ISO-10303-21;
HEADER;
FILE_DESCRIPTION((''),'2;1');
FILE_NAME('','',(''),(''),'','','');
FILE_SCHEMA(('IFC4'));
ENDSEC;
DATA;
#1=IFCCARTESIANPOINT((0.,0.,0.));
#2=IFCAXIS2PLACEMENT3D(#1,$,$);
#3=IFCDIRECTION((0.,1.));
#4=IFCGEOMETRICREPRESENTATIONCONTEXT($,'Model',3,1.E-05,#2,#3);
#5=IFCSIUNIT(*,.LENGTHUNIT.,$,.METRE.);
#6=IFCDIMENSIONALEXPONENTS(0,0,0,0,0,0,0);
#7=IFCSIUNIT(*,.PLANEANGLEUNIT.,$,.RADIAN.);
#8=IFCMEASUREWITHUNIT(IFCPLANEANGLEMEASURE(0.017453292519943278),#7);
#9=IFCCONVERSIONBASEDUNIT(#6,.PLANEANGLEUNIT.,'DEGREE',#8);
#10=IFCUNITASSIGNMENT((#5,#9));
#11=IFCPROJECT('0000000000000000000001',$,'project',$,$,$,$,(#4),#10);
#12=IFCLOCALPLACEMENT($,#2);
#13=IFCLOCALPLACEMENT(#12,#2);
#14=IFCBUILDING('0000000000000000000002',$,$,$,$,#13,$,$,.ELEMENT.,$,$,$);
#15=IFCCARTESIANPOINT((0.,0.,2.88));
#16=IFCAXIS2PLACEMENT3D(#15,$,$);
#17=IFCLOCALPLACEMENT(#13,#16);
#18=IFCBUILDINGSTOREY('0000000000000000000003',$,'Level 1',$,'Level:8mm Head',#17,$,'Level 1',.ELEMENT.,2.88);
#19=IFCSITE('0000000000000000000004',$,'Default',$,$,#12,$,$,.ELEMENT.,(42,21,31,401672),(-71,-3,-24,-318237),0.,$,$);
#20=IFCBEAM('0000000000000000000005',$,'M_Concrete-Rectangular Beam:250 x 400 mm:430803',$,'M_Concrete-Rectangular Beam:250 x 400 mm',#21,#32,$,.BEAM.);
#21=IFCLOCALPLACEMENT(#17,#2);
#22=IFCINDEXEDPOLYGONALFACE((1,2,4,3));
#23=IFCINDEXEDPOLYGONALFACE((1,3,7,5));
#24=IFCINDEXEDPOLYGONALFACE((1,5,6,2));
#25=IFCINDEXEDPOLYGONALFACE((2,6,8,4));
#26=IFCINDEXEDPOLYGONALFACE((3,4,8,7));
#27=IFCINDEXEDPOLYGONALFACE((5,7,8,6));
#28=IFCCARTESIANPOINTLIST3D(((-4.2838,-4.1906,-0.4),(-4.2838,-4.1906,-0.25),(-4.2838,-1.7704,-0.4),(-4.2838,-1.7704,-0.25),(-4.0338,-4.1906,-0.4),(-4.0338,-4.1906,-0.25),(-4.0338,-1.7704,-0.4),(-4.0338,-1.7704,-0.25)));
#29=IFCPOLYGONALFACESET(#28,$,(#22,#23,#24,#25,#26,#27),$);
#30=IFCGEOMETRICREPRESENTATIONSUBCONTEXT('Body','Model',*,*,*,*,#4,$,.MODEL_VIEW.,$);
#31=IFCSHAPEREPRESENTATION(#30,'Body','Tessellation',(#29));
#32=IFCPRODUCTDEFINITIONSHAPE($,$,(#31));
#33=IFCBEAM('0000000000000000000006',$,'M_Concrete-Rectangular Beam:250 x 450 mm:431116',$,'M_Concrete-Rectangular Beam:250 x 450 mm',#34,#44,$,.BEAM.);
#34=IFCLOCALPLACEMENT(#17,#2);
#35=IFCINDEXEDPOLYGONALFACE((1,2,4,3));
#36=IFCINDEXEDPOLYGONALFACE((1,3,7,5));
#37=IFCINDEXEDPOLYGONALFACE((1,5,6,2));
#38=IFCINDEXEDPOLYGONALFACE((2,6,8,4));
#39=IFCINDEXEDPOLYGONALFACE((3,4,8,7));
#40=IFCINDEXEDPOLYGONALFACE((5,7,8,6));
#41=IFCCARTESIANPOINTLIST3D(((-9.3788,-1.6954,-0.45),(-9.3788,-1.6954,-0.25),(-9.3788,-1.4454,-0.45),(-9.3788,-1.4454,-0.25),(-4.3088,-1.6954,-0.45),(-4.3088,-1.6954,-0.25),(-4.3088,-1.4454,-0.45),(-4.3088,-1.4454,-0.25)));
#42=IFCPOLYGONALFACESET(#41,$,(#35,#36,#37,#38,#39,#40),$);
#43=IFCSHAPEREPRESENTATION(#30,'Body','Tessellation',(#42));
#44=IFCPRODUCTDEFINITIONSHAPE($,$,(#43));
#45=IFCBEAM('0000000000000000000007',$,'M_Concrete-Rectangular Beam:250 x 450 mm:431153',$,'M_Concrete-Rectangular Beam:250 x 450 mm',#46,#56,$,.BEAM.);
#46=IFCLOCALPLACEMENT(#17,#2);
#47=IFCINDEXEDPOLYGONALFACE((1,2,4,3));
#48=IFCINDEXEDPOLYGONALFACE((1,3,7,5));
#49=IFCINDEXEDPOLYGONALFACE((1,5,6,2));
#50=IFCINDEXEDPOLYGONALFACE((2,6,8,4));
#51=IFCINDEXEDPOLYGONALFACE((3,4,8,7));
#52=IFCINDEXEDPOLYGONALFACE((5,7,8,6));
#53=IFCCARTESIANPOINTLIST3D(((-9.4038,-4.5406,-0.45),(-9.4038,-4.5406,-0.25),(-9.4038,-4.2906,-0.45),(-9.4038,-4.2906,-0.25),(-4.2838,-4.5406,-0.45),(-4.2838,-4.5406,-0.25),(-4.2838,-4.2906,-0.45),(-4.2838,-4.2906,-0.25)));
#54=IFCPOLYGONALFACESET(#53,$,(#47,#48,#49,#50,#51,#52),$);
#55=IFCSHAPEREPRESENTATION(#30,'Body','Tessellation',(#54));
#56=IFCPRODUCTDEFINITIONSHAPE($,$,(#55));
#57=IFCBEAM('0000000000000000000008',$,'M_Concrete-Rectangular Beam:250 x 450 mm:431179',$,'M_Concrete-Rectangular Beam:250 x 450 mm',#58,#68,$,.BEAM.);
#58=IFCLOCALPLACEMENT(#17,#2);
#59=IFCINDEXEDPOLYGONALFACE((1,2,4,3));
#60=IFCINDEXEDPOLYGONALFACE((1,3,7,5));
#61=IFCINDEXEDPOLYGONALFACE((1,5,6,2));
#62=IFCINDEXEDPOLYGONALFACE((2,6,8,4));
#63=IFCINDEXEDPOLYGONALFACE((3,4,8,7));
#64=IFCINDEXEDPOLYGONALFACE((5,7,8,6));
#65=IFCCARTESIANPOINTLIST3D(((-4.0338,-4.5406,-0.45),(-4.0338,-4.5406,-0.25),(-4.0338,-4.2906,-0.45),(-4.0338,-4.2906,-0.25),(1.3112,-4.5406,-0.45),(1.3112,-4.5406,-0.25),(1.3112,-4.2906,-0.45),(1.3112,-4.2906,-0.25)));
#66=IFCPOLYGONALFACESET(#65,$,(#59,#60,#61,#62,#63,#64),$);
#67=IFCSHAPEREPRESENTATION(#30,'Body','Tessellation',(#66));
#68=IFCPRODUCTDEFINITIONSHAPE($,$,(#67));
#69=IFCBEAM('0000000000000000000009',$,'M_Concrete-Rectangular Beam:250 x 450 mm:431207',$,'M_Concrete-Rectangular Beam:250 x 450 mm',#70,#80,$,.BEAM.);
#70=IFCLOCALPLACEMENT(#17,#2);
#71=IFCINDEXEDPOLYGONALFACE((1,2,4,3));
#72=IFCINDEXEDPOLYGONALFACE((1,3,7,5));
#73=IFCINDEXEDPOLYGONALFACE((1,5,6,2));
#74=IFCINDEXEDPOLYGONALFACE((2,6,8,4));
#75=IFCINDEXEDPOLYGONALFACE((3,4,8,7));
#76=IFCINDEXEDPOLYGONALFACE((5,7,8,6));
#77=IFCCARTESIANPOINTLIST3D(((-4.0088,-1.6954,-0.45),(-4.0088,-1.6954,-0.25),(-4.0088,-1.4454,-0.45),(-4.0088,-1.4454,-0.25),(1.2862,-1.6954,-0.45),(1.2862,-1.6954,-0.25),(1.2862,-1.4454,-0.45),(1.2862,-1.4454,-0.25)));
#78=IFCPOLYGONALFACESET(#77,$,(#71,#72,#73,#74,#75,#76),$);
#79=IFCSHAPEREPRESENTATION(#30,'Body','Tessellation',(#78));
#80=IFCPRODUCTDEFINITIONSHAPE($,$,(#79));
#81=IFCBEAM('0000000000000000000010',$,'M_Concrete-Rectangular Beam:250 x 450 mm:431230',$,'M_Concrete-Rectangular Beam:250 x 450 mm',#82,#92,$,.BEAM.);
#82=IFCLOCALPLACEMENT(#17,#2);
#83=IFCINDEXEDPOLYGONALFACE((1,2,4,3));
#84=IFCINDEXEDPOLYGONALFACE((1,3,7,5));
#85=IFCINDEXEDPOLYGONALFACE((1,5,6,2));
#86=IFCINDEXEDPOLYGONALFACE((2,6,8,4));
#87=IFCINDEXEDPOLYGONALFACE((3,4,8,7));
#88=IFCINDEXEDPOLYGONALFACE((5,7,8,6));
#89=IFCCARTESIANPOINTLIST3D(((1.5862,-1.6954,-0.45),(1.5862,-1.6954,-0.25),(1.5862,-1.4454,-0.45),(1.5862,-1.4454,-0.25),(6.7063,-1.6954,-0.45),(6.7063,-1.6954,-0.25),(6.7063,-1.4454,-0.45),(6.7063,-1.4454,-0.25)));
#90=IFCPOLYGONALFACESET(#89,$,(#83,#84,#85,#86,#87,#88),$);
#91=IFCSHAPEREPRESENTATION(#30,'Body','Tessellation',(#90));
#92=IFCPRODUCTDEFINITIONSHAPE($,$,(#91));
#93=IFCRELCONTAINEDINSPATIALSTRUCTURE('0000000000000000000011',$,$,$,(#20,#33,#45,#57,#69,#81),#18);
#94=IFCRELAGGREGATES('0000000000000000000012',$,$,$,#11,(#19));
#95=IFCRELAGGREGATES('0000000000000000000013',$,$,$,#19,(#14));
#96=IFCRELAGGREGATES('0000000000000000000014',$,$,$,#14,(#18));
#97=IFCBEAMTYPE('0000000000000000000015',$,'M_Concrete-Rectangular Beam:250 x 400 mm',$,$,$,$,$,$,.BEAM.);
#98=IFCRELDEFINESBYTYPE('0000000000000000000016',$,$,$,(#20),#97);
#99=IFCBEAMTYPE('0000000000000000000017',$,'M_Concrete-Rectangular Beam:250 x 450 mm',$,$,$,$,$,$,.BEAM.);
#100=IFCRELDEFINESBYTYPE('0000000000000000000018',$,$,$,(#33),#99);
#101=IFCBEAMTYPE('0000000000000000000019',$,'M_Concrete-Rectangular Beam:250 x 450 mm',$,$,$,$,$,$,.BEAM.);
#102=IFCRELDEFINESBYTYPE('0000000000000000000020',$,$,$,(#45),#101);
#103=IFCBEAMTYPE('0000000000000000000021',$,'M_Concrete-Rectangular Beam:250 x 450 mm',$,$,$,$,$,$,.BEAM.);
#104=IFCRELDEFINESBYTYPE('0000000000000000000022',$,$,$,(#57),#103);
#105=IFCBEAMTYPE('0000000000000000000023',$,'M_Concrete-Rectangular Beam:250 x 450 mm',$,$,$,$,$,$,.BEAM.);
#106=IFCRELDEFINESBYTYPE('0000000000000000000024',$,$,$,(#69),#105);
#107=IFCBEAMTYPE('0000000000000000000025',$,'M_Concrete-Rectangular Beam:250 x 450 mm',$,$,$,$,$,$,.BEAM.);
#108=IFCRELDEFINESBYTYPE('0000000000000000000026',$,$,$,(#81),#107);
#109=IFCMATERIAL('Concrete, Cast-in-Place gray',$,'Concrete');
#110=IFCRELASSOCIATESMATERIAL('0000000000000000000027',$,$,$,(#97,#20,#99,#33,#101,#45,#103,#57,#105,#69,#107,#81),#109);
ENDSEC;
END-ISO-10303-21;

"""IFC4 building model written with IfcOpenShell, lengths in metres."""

from ifc_helpers import new_model, entity, si_unit, converted_unit, direction, frame, origin, place, context, subcontext, project, spatial, indexed_curve, outline, extrude, source, transform, mapped, material, type_object, type_shapes, element, save


model = new_model("IFC4")

# Units and contexts
model_context = context("Model", 3, precision=1e-05, world=origin(), true_north=direction((0.0, 1.0)))
body_context = subcontext(model_context, "Body", "Model", "MODEL_VIEW")
ifc_project = project(units=[si_unit("LENGTHUNIT", "METRE"), converted_unit("PLANEANGLEUNIT", "DEGREE", entity("IfcPlaneAngleMeasure", 0.017453292519943278), si_unit("PLANEANGLEUNIT", "RADIAN"), dimensions=[0, 0, 0, 0, 0, 0, 0])], contexts=[model_context])

# Site, building, storey
site_placement = place(None, origin())
site = spatial("IfcSite", under=ifc_project, at=site_placement, Name="Default", CompositionType="ELEMENT", RefLatitude=(42, 21, 31, 401672), RefLongitude=(-71, -3, -24, -318237), RefElevation=0.0)
building_placement = place(site_placement, origin())
building = spatial("IfcBuilding", under=site, at=building_placement, CompositionType="ELEMENT")
storey_placement = place(building_placement, frame((0.0, 0.0, 2.88)))
storey = spatial("IfcBuildingStorey", under=building, at=storey_placement, Name="Level 1", ObjectType="Level:8mm Head", LongName="Level 1", CompositionType="ELEMENT", Elevation=2.88)

# Shared definitions
ifc_material = material(Name="Concrete, Cast-in-Place gray", Category="Concrete")

# Beams
beam_type_1 = type_object("IfcBeamType", Name="M_Concrete-Rectangular Beam:250 x 400 mm", PredefinedType="BEAM", material=ifc_material)
shared_shape_1 = source(origin(), body_context, "Body", "SweptSolid", [
    extrude(outline(indexed_curve([(-0.125, -0.075), (0.125, -0.075), (0.125, 0.075), (-0.125, 0.075), (-0.125, -0.075)], self_intersect=False)), frame((-4.1588, -1.7704, 2.555), z_axis=(0.0, -1.0, 0.0), x_axis=(-1.0, 0.0, 0.0)), (0.0, 0.0, 1.0), 2.4202),
])
type_shapes(beam_type_1, [shared_shape_1])
beam_1_placement = place(storey_placement, frame((0.0, 0.0, -2.88)))
element("IfcBeam", 1, at=beam_1_placement, inside=storey, type_object=beam_type_1, material=ifc_material, Name="M_Concrete-Rectangular Beam:250 x 400 mm:430803", ObjectType="M_Concrete-Rectangular Beam:250 x 400 mm", PredefinedType="BEAM", context=body_context, shape_type="MappedRepresentation", body=[
    mapped(shared_shape_1, transform((0.0, 0.0, 0.0), scale=1.0)),
])
beam_type_2 = type_object("IfcBeamType", Name="M_Concrete-Rectangular Beam:250 x 450 mm", PredefinedType="BEAM", material=ifc_material)
shared_shape_2 = source(origin(), body_context, "Body", "SweptSolid", [
    extrude(outline(indexed_curve([(-0.1, -0.125), (0.1, -0.125), (0.1, 0.125), (-0.1, 0.125), (-0.1, -0.125)], self_intersect=False)), frame((-9.3788, -1.5704, 2.53), z_axis=(1.0, 0.0, 0.0), x_axis=(0.0, 0.0, -1.0)), (0.0, 0.0, 1.0), 5.07),
])
type_shapes(beam_type_2, [shared_shape_2])
beam_2_placement = place(storey_placement, frame((0.0, 0.0, -2.88)))
element("IfcBeam", 2, at=beam_2_placement, inside=storey, type_object=beam_type_2, material=ifc_material, Name="M_Concrete-Rectangular Beam:250 x 450 mm:431116", ObjectType="M_Concrete-Rectangular Beam:250 x 450 mm", PredefinedType="BEAM", context=body_context, shape_type="MappedRepresentation", body=[
    mapped(shared_shape_2, transform((0.0, 0.0, 0.0), scale=1.0)),
])
beam_type_3 = type_object("IfcBeamType", Name="M_Concrete-Rectangular Beam:250 x 450 mm", PredefinedType="BEAM", material=ifc_material)
shared_shape_3 = source(origin(), body_context, "Body", "SweptSolid", [
    extrude(outline(indexed_curve([(-0.1, -0.125), (0.1, -0.125), (0.1, 0.125), (-0.1, 0.125), (-0.1, -0.125)], self_intersect=False)), frame((-9.4038, -4.4156, 2.53), z_axis=(1.0, 0.0, 0.0), x_axis=(0.0, 0.0, -1.0)), (0.0, 0.0, 1.0), 5.12),
])
type_shapes(beam_type_3, [shared_shape_3])
beam_3_placement = place(storey_placement, frame((0.0, 0.0, -2.88)))
element("IfcBeam", 3, at=beam_3_placement, inside=storey, type_object=beam_type_3, material=ifc_material, Name="M_Concrete-Rectangular Beam:250 x 450 mm:431153", ObjectType="M_Concrete-Rectangular Beam:250 x 450 mm", PredefinedType="BEAM", context=body_context, shape_type="MappedRepresentation", body=[
    mapped(shared_shape_3, transform((0.0, 0.0, 0.0), scale=1.0)),
])
beam_type_4 = type_object("IfcBeamType", Name="M_Concrete-Rectangular Beam:250 x 450 mm", PredefinedType="BEAM", material=ifc_material)
shared_shape_4 = source(origin(), body_context, "Body", "SweptSolid", [
    extrude(outline(indexed_curve([(-0.1, -0.125), (0.1, -0.125), (0.1, 0.125), (-0.1, 0.125), (-0.1, -0.125)], self_intersect=False)), frame((-4.0338, -4.4156, 2.53), z_axis=(1.0, 0.0, 0.0), x_axis=(0.0, 0.0, -1.0)), (0.0, 0.0, 1.0), 5.345),
])
type_shapes(beam_type_4, [shared_shape_4])
beam_4_placement = place(storey_placement, frame((0.0, 0.0, -2.88)))
element("IfcBeam", 4, at=beam_4_placement, inside=storey, type_object=beam_type_4, material=ifc_material, Name="M_Concrete-Rectangular Beam:250 x 450 mm:431179", ObjectType="M_Concrete-Rectangular Beam:250 x 450 mm", PredefinedType="BEAM", context=body_context, shape_type="MappedRepresentation", body=[
    mapped(shared_shape_4, transform((0.0, 0.0, 0.0), scale=1.0)),
])
beam_type_5 = type_object("IfcBeamType", Name="M_Concrete-Rectangular Beam:250 x 450 mm", PredefinedType="BEAM", material=ifc_material)
shared_shape_5 = source(origin(), body_context, "Body", "SweptSolid", [
    extrude(outline(indexed_curve([(-0.1, -0.125), (0.1, -0.125), (0.1, 0.125), (-0.1, 0.125), (-0.1, -0.125)], self_intersect=False)), frame((-4.0088, -1.5704, 2.53), z_axis=(1.0, 0.0, 0.0), x_axis=(0.0, 0.0, -1.0)), (0.0, 0.0, 1.0), 5.295),
])
type_shapes(beam_type_5, [shared_shape_5])
beam_5_placement = place(storey_placement, frame((0.0, 0.0, -2.88)))
element("IfcBeam", 5, at=beam_5_placement, inside=storey, type_object=beam_type_5, material=ifc_material, Name="M_Concrete-Rectangular Beam:250 x 450 mm:431207", ObjectType="M_Concrete-Rectangular Beam:250 x 450 mm", PredefinedType="BEAM", context=body_context, shape_type="MappedRepresentation", body=[
    mapped(shared_shape_5, transform((0.0, 0.0, 0.0), scale=1.0)),
])
beam_type_6 = type_object("IfcBeamType", Name="M_Concrete-Rectangular Beam:250 x 450 mm", PredefinedType="BEAM", material=ifc_material)
shared_shape_6 = source(origin(), body_context, "Body", "SweptSolid", [
    extrude(outline(indexed_curve([(-0.1, -0.125), (0.1, -0.125), (0.1, 0.125), (-0.1, 0.125), (-0.1, -0.125)], self_intersect=False)), frame((1.5862, -1.5704, 2.53), z_axis=(1.0, 0.0, 0.0), x_axis=(0.0, 0.0, -1.0)), (0.0, 0.0, 1.0), 5.1201),
])
type_shapes(beam_type_6, [shared_shape_6])
beam_6_placement = place(storey_placement, frame((0.0, 0.0, -2.88)))
element("IfcBeam", 6, at=beam_6_placement, inside=storey, type_object=beam_type_6, material=ifc_material, Name="M_Concrete-Rectangular Beam:250 x 450 mm:431230", ObjectType="M_Concrete-Rectangular Beam:250 x 450 mm", PredefinedType="BEAM", context=body_context, shape_type="MappedRepresentation", body=[
    mapped(shared_shape_6, transform((0.0, 0.0, 0.0), scale=1.0)),
])

save(model, "model.ifc")
